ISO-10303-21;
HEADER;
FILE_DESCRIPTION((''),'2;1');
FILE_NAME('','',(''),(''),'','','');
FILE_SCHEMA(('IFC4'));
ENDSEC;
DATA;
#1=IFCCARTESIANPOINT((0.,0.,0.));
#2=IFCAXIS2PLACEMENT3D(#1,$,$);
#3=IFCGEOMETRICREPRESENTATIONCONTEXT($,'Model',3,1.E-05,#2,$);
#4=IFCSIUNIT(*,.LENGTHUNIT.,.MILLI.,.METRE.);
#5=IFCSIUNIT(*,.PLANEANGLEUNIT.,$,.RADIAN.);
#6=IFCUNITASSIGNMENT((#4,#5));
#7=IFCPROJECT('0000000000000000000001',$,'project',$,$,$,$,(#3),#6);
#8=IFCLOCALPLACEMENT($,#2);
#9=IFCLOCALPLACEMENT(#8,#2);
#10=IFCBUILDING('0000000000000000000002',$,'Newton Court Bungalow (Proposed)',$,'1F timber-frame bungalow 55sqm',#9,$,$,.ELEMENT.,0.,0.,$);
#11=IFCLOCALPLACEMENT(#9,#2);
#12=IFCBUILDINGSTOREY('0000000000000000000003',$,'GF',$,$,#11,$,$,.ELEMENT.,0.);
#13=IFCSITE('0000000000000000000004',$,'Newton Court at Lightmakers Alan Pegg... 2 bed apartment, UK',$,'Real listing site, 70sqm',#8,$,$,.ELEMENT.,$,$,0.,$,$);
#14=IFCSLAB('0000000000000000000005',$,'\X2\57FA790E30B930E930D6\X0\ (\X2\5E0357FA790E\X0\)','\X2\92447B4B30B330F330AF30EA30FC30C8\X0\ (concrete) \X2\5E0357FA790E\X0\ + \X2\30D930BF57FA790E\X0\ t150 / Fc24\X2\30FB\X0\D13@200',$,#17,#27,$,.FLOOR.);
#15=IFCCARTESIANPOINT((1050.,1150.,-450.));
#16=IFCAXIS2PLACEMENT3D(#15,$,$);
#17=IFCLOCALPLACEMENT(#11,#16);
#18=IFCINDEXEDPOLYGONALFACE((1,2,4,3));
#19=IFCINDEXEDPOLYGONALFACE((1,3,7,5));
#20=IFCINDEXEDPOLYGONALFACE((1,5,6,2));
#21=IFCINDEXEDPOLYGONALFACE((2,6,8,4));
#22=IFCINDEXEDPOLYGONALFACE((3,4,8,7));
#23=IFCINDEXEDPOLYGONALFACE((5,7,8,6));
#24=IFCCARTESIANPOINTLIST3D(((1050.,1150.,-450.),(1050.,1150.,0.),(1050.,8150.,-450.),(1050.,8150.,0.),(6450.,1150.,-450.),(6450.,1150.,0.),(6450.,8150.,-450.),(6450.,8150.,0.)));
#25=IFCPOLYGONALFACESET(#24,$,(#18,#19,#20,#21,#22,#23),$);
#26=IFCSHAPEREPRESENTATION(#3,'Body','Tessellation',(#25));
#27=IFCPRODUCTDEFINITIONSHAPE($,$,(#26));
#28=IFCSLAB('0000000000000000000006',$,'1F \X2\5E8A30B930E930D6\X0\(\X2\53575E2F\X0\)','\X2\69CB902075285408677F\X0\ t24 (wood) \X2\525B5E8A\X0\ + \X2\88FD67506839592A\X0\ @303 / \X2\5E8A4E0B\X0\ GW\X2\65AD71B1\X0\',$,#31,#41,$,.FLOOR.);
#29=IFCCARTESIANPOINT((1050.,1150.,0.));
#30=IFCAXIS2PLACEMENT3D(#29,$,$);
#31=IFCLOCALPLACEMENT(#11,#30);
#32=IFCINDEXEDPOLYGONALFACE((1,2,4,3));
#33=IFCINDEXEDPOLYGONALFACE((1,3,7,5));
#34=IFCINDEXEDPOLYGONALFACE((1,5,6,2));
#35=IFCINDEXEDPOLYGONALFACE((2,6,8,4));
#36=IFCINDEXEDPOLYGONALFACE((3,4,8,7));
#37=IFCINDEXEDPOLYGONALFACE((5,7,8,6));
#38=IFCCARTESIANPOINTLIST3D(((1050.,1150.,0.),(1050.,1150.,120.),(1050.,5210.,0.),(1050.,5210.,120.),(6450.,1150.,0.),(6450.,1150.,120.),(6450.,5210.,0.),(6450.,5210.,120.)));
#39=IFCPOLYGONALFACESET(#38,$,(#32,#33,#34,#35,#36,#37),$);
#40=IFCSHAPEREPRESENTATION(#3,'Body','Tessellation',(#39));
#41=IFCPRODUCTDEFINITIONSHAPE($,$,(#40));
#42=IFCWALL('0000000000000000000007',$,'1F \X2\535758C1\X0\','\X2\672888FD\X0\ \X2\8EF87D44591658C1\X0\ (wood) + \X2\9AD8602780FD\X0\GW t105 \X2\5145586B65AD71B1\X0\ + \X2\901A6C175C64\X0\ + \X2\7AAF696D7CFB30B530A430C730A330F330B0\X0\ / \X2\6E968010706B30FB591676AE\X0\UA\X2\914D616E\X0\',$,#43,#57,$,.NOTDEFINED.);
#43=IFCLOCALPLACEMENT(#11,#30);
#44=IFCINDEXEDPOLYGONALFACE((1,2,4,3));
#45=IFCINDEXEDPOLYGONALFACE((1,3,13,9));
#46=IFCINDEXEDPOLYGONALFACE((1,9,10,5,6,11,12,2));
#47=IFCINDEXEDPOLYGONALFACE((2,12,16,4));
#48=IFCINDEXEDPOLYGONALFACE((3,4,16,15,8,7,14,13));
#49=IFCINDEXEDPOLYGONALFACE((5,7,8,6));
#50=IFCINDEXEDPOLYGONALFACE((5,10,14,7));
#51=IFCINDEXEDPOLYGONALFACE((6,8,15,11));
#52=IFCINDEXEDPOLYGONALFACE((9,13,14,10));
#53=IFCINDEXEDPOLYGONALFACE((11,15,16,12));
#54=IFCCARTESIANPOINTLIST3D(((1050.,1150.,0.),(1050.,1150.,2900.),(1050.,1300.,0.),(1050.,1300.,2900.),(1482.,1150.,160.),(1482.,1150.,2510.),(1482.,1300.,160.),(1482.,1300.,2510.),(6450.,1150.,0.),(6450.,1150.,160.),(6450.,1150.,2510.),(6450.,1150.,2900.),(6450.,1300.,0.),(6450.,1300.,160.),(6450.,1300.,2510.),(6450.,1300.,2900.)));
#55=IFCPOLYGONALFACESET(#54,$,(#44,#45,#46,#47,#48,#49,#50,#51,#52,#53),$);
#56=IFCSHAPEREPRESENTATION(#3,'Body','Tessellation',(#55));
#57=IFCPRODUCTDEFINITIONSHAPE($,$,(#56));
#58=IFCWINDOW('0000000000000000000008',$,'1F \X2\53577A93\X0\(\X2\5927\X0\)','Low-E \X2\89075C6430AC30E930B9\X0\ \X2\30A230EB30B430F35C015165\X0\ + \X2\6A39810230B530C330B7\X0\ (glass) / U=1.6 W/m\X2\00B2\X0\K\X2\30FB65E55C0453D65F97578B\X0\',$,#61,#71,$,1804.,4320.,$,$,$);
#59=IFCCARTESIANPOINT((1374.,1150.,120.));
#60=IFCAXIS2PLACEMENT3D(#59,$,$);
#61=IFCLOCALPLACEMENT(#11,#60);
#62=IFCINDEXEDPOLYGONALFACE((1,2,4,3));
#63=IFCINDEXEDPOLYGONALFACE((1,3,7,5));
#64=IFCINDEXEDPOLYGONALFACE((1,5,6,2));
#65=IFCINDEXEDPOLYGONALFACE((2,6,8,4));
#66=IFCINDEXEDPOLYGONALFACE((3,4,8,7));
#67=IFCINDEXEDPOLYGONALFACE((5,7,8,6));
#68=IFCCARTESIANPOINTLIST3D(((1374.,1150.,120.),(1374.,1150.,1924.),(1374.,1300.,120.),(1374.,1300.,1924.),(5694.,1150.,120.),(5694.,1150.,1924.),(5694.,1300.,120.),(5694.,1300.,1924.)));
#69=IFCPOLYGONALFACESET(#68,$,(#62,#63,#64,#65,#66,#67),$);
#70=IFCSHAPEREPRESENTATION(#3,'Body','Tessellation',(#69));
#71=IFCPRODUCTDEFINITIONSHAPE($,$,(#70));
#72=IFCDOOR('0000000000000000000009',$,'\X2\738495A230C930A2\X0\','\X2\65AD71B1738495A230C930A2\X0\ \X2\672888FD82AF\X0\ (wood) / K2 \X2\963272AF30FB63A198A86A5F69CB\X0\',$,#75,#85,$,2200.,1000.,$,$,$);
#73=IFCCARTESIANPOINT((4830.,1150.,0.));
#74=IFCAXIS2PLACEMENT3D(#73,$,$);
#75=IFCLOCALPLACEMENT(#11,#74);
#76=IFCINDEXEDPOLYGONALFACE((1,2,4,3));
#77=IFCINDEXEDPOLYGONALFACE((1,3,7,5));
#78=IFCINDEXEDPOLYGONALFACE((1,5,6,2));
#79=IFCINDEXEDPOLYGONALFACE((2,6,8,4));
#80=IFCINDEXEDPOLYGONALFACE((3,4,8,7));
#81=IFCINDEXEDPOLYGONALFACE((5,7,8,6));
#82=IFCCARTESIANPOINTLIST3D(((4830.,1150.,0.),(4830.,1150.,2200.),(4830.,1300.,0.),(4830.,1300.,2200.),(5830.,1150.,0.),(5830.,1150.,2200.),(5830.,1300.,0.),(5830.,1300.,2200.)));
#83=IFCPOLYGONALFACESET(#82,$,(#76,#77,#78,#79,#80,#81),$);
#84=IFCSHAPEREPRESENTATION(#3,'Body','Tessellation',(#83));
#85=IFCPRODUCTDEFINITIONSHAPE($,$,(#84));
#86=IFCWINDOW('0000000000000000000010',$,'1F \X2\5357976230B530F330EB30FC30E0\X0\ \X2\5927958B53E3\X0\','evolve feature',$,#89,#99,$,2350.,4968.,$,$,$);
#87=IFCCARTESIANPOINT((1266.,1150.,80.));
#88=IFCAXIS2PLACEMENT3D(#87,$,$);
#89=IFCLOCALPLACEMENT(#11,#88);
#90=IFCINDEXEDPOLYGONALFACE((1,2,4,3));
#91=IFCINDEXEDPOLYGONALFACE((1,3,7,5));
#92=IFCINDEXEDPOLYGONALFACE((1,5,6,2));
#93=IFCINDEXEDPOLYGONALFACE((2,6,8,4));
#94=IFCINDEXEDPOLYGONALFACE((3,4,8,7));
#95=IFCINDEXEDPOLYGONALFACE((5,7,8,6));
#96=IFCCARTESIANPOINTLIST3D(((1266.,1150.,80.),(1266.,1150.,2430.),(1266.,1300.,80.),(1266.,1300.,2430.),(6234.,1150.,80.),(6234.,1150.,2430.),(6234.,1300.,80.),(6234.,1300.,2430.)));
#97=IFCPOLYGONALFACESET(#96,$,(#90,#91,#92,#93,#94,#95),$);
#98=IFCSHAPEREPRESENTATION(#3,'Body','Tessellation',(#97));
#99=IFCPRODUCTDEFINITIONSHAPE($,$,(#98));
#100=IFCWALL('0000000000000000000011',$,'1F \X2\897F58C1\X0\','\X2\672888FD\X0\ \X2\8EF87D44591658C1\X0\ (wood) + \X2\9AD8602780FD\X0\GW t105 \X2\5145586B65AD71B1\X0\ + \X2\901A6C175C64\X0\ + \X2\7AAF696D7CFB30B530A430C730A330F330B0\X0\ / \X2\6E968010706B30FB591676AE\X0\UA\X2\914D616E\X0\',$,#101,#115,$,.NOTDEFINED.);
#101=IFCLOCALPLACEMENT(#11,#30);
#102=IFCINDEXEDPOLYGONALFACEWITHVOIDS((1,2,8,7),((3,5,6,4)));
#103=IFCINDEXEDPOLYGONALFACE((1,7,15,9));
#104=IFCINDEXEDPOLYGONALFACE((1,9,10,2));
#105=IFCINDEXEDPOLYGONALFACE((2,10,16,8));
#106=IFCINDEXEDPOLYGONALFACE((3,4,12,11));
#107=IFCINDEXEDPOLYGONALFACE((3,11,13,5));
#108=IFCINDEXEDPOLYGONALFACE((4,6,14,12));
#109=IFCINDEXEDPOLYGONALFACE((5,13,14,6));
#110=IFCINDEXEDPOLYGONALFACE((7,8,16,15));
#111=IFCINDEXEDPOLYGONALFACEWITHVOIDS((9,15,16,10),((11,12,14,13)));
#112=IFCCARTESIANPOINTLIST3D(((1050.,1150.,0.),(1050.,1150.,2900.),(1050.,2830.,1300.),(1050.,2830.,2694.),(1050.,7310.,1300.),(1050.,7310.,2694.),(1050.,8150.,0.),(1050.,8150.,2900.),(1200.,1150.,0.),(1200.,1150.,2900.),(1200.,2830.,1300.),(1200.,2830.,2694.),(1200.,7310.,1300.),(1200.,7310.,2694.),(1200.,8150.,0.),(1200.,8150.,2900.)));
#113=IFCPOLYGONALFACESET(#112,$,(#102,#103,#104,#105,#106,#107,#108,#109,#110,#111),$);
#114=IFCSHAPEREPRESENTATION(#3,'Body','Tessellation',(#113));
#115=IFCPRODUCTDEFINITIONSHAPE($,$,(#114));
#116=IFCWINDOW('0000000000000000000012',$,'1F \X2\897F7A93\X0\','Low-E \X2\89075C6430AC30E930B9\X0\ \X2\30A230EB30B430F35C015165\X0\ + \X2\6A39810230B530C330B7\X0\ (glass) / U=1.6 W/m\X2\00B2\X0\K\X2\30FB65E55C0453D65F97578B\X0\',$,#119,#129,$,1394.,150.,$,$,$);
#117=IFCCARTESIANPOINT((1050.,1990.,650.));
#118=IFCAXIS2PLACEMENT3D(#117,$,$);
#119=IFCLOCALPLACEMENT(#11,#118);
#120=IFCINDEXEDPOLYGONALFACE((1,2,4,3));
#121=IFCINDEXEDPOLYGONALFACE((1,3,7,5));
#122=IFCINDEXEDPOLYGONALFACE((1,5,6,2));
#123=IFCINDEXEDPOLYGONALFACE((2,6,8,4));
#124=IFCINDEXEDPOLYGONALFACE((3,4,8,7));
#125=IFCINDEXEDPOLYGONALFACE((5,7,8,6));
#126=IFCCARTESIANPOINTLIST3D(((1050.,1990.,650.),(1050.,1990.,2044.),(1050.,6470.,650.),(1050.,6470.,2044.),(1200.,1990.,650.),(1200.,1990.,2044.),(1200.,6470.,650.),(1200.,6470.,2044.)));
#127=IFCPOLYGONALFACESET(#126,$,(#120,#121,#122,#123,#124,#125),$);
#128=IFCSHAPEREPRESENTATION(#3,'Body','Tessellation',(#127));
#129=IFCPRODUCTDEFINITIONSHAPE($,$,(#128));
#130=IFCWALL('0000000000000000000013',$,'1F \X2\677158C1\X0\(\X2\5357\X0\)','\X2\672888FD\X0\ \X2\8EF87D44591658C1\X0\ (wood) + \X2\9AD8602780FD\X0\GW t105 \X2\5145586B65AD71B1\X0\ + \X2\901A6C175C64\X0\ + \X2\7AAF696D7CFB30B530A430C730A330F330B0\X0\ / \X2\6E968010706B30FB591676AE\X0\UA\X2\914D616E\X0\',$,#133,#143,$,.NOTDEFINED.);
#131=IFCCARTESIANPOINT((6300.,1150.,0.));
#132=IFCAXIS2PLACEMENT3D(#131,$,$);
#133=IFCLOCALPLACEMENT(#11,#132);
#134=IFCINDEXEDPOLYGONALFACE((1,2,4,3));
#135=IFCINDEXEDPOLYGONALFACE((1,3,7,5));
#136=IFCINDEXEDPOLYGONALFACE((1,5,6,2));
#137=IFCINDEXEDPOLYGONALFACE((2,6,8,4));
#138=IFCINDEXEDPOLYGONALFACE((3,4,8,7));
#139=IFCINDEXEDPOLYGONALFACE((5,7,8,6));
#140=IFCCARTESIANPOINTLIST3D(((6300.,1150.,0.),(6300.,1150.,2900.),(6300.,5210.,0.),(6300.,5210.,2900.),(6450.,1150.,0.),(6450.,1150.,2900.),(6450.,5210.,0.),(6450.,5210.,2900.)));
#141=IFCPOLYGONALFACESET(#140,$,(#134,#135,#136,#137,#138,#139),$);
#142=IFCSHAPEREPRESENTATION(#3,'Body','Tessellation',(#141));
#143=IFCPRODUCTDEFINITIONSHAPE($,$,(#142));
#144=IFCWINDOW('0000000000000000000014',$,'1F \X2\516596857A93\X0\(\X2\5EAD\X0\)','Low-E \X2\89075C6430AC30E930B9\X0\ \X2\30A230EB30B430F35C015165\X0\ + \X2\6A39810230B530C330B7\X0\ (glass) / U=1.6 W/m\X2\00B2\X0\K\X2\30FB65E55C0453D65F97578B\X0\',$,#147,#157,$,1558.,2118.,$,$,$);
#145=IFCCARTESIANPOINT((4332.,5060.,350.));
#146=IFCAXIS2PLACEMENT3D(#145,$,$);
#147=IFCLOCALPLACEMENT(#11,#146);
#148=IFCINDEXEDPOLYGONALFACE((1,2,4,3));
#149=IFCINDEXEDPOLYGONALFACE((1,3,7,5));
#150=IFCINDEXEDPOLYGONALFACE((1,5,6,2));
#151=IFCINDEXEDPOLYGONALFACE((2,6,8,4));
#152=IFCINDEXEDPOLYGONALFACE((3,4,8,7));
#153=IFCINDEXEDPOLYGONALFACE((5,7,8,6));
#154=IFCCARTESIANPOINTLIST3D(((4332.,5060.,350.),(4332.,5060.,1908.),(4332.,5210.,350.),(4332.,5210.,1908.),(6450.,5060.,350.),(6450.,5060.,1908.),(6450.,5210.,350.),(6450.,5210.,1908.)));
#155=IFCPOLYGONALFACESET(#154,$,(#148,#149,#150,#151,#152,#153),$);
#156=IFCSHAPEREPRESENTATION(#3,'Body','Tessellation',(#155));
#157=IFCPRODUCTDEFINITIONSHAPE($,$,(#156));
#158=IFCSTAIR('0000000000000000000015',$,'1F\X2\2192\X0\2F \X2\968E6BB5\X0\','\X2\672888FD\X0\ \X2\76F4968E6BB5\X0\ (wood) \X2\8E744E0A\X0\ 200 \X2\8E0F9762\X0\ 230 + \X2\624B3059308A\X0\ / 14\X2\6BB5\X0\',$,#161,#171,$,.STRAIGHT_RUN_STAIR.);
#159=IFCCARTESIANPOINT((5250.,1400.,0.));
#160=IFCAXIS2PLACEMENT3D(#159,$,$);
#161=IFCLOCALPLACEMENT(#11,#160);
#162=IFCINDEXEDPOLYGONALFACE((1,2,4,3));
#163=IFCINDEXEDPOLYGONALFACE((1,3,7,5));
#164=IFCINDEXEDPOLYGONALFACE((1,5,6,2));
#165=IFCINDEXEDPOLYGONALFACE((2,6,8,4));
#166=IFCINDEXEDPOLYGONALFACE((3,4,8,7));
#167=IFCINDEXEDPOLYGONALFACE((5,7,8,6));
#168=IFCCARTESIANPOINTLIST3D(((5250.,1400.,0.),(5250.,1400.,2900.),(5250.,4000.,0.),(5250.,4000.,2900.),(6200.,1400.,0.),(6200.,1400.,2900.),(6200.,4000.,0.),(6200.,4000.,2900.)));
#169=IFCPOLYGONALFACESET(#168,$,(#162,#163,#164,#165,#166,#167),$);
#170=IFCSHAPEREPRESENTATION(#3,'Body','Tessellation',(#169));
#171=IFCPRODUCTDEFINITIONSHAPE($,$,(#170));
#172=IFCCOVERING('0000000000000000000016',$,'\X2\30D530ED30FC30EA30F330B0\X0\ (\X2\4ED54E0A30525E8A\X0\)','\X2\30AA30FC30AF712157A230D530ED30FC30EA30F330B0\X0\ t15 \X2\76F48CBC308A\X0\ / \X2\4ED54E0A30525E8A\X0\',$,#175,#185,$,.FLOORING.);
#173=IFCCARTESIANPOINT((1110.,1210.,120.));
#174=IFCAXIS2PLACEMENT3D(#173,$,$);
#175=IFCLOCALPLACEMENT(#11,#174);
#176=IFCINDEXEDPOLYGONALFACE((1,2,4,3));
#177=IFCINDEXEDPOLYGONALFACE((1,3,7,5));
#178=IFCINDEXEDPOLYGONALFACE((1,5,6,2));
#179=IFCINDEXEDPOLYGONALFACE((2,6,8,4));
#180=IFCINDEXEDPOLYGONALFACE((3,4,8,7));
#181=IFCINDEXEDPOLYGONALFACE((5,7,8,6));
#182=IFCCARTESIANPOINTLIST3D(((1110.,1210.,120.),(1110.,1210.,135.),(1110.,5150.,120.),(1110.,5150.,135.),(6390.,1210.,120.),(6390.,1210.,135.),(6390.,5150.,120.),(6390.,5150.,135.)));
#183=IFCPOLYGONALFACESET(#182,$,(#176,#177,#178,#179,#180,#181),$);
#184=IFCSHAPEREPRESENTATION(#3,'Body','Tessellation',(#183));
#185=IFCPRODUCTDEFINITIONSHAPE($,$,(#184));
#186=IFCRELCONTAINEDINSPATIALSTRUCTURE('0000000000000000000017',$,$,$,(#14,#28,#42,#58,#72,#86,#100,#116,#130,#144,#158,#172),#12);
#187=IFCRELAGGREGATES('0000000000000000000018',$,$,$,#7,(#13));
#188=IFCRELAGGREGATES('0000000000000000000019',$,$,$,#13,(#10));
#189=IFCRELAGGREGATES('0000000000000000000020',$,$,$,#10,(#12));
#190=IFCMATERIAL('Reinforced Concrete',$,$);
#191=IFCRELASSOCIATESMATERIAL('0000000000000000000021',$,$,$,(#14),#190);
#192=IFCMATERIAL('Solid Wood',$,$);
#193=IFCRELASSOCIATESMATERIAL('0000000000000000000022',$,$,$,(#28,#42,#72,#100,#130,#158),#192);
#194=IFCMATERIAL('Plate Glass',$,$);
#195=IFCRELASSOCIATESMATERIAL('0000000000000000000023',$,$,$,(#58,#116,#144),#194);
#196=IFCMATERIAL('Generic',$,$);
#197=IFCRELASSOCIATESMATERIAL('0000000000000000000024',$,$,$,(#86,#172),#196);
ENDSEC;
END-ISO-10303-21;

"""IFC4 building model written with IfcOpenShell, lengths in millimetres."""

from ifc_helpers import new_model, si_unit, frame, frame_2d, origin, place, context, project, spatial, rectangle, extrude, material, element, fill, save


model = new_model("IFC4")

# Units and contexts
model_context = context("Model", 3, precision=1e-05, world=origin())
ifc_project = project(units=[si_unit("LENGTHUNIT", "METRE", prefix="MILLI"), si_unit("PLANEANGLEUNIT", "RADIAN")], contexts=[model_context])

# Site, building, storey
site_placement = place(None, origin())
site = spatial("IfcSite", under=ifc_project, at=site_placement, Name="Newton Court at Lightmakers Alan Pegg... 2 bed apartment, UK", ObjectType="Real listing site, 70sqm", CompositionType="ELEMENT", RefElevation=0.0)
building_placement = place(site_placement, origin())
building = spatial("IfcBuilding", under=site, at=building_placement, Name="Newton Court Bungalow (Proposed)", ObjectType="1F timber-frame bungalow 55sqm", CompositionType="ELEMENT", ElevationOfRefHeight=0.0, ElevationOfTerrain=0.0)
storey_placement = place(building_placement, origin())
storey = spatial("IfcBuildingStorey", under=building, at=storey_placement, Name="GF", CompositionType="ELEMENT", Elevation=0.0)

# Slabs
ifc_material_1 = material(Name="Reinforced Concrete")
slab_1_placement = place(storey_placement, frame((1050.0, 1150.0, -450.0)))
element("IfcSlab", 1, at=slab_1_placement, inside=storey, material=ifc_material_1, Name="基礎スラブ (布基礎)", Description="鉄筋コンクリート (concrete) 布基礎 + ベタ基礎 t150 / Fc24・D13@200", PredefinedType="FLOOR", context=model_context, shape_type="SweptSolid", body=[
    extrude(rectangle(XDim=5400.0, YDim=7000.0, at=frame_2d((2700.0, 3500.0))), frame((1050.0, 1150.0, -450.0)), (0.0, 0.0, 1.0), 450.0),
])
ifc_material_2 = material(Name="Solid Wood")
slab_2_placement = place(storey_placement, frame((1050.0, 1150.0, 0.0)))
element("IfcSlab", 2, at=slab_2_placement, inside=storey, material=ifc_material_2, Name="1F 床スラブ(南帯)", Description="構造用合板 t24 (wood) 剛床 + 製材根太 @303 / 床下 GW断熱", PredefinedType="FLOOR", context=model_context, shape_type="SweptSolid", body=[
    extrude(rectangle(XDim=5400.0, YDim=4060.0, at=frame_2d((2700.0, 2030.0))), frame((1050.0, 1150.0, 0.0)), (0.0, 0.0, 1.0), 120.0),
])

# Wall, openings, windows, door
wall_1_placement = place(storey_placement, frame((1050.0, 1150.0, 0.0)))
wall_1 = element("IfcWall", 3, at=wall_1_placement, inside=storey, material=ifc_material_2, Name="1F 南壁", Description="木製 軸組外壁 (wood) + 高性能GW t105 充填断熱 + 通気層 + 窯業系サイディング / 準耐火・外皮UA配慮", PredefinedType="NOTDEFINED", context=model_context, shape_type="SweptSolid", body=[
    extrude(rectangle(XDim=5400.0, YDim=150.0, at=frame_2d((2700.0, 75.0))), frame((1050.0, 1150.0, 0.0)), (0.0, 0.0, 1.0), 2900.0),
])
opening_1_placement = place(storey_placement, frame((1374.0, 1150.0, 120.0)))
opening_1 = element("IfcOpeningElement", 4, at=opening_1_placement, cuts=wall_1, PredefinedType="NOTDEFINED", context=model_context, shape_type="SweptSolid", body=[
    extrude(rectangle(XDim=4320.0, YDim=150.0, at=frame_2d((2160.0, 75.0))), frame((1374.0, 1150.0, 120.0)), (0.0, 0.0, 1.0), 1804.0),
])
opening_2_placement = place(storey_placement, frame((4830.0, 1150.0, 0.0)))
opening_2 = element("IfcOpeningElement", 5, at=opening_2_placement, cuts=wall_1, PredefinedType="NOTDEFINED", context=model_context, shape_type="SweptSolid", body=[
    extrude(rectangle(XDim=1000.0, YDim=150.0, at=frame_2d((500.0, 75.0))), frame((4830.0, 1150.0, 0.0)), (0.0, 0.0, 1.0), 2200.0),
])
opening_3_placement = place(storey_placement, frame((1266.0, 1150.0, 80.0)))
opening_3 = element("IfcOpeningElement", 6, at=opening_3_placement, cuts=wall_1, PredefinedType="NOTDEFINED", context=model_context, shape_type="SweptSolid", body=[
    extrude(rectangle(XDim=4968.0, YDim=150.0, at=frame_2d((2484.0, 75.0))), frame((1266.0, 1150.0, 80.0)), (0.0, 0.0, 1.0), 2350.0),
])
ifc_material_3 = material(Name="Plate Glass")
window_1_placement = place(storey_placement, frame((1374.0, 1150.0, 120.0)))
window_1 = element("IfcWindow", 7, at=window_1_placement, inside=storey, material=ifc_material_3, Name="1F 南窓(大)", Description="Low-E 複層ガラス アルゴン封入 + 樹脂サッシ (glass) / U=1.6 W/m²K・日射取得型", OverallHeight=1804.0, OverallWidth=4320.0, context=model_context, shape_type="SweptSolid", body=[
    extrude(rectangle(XDim=4320.0, YDim=150.0, at=frame_2d((2160.0, 75.0))), frame((1374.0, 1150.0, 120.0)), (0.0, 0.0, 1.0), 1804.0),
])
fill(opening_1, window_1)
door_1_placement = place(storey_placement, frame((4830.0, 1150.0, 0.0)))
door_1 = element("IfcDoor", 8, at=door_1_placement, inside=storey, material=ifc_material_2, Name="玄関ドア", Description="断熱玄関ドア 木製芯 (wood) / K2 防犯・採風機構", OverallHeight=2200.0, OverallWidth=1000.0, context=model_context, shape_type="SweptSolid", body=[
    extrude(rectangle(XDim=1000.0, YDim=150.0, at=frame_2d((500.0, 75.0))), frame((4830.0, 1150.0, 0.0)), (0.0, 0.0, 1.0), 2200.0),
])
fill(opening_2, door_1)
ifc_material_4 = material(Name="Generic")
window_2_placement = place(storey_placement, frame((1266.0, 1150.0, 80.0)))
window_2 = element("IfcWindow", 9, at=window_2_placement, inside=storey, material=ifc_material_4, Name="1F 南面サンルーム 大開口", Description="evolve feature", OverallHeight=2350.0, OverallWidth=4968.0, context=model_context, shape_type="SweptSolid", body=[
    extrude(rectangle(XDim=4968.0, YDim=150.0, at=frame_2d((2484.0, 75.0))), frame((1266.0, 1150.0, 80.0)), (0.0, 0.0, 1.0), 2350.0),
])
fill(opening_3, window_2)

# Walls, openings, windows
wall_2_placement = place(storey_placement, frame((1050.0, 1150.0, 0.0)))
wall_2 = element("IfcWall", 10, at=wall_2_placement, inside=storey, material=ifc_material_2, Name="1F 西壁", Description="木製 軸組外壁 (wood) + 高性能GW t105 充填断熱 + 通気層 + 窯業系サイディング / 準耐火・外皮UA配慮", PredefinedType="NOTDEFINED", context=model_context, shape_type="SweptSolid", body=[
    extrude(rectangle(XDim=150.0, YDim=7000.0, at=frame_2d((75.0, 3500.0))), frame((1050.0, 1150.0, 0.0)), (0.0, 0.0, 1.0), 2900.0),
])
opening_4_placement = place(storey_placement, frame((1050.0, 1990.0, 650.0)))
opening_4 = element("IfcOpeningElement", 11, at=opening_4_placement, cuts=wall_2, PredefinedType="NOTDEFINED", context=model_context, shape_type="SweptSolid", body=[
    extrude(rectangle(XDim=150.0, YDim=4480.0, at=frame_2d((75.0, 2240.0))), frame((1050.0, 1990.0, 650.0)), (0.0, 0.0, 1.0), 1394.0),
])
window_3_placement = place(storey_placement, frame((1050.0, 1990.0, 650.0)))
window_3 = element("IfcWindow", 12, at=window_3_placement, inside=storey, material=ifc_material_3, Name="1F 西窓", Description="Low-E 複層ガラス アルゴン封入 + 樹脂サッシ (glass) / U=1.6 W/m²K・日射取得型", OverallHeight=1394.0, OverallWidth=150.0, context=model_context, shape_type="SweptSolid", body=[
    extrude(rectangle(XDim=150.0, YDim=4480.0, at=frame_2d((75.0, 2240.0))), frame((1050.0, 1990.0, 650.0)), (0.0, 0.0, 1.0), 1394.0),
])
fill(opening_4, window_3)
wall_3_placement = place(storey_placement, frame((6300.0, 1150.0, 0.0)))
wall_3 = element("IfcWall", 13, at=wall_3_placement, inside=storey, material=ifc_material_2, Name="1F 東壁(南)", Description="木製 軸組外壁 (wood) + 高性能GW t105 充填断熱 + 通気層 + 窯業系サイディング / 準耐火・外皮UA配慮", PredefinedType="NOTDEFINED", context=model_context, shape_type="SweptSolid", body=[
    extrude(rectangle(XDim=150.0, YDim=4060.0, at=frame_2d((75.0, 2030.0))), frame((6300.0, 1150.0, 0.0)), (0.0, 0.0, 1.0), 2900.0),
])
opening_5_placement = place(storey_placement, frame((4332.0, 5060.0, 350.0)))
opening_5 = element("IfcOpeningElement", 14, at=opening_5_placement, cuts=wall_3, PredefinedType="NOTDEFINED", context=model_context, shape_type="SweptSolid", body=[
    extrude(rectangle(XDim=2118.0, YDim=150.0, at=frame_2d((1059.0, 75.0))), frame((4332.0, 5060.0, 350.0)), (0.0, 0.0, 1.0), 1558.0),
])
window_4_placement = place(storey_placement, frame((4332.0, 5060.0, 350.0)))
window_4 = element("IfcWindow", 15, at=window_4_placement, inside=storey, material=ifc_material_3, Name="1F 入隅窓(庭)", Description="Low-E 複層ガラス アルゴン封入 + 樹脂サッシ (glass) / U=1.6 W/m²K・日射取得型", OverallHeight=1558.0, OverallWidth=2118.0, context=model_context, shape_type="SweptSolid", body=[
    extrude(rectangle(XDim=2118.0, YDim=150.0, at=frame_2d((1059.0, 75.0))), frame((4332.0, 5060.0, 350.0)), (0.0, 0.0, 1.0), 1558.0),
])
fill(opening_5, window_4)

# Stair
stair_placement = place(storey_placement, frame((5250.0, 1400.0, 0.0)))
element("IfcStair", 16, at=stair_placement, inside=storey, material=ifc_material_2, Name="1F→2F 階段", Description="木製 直階段 (wood) 蹴上 200 踏面 230 + 手すり / 14段", PredefinedType="STRAIGHT_RUN_STAIR", context=model_context, shape_type="SweptSolid", body=[
    extrude(rectangle(XDim=950.0, YDim=2600.0, at=frame_2d((475.0, 1300.0))), frame((5250.0, 1400.0, 0.0)), (0.0, 0.0, 1.0), 2900.0),
])

# Covering
covering_placement = place(storey_placement, frame((1110.0, 1210.0, 120.0)))
element("IfcCovering", 17, at=covering_placement, inside=storey, material=ifc_material_4, Name="フローリング (仕上げ床)", Description="オーク無垢フローリング t15 直貼り / 仕上げ床", PredefinedType="FLOORING", context=model_context, shape_type="SweptSolid", body=[
    extrude(rectangle(XDim=5280.0, YDim=3940.0, at=frame_2d((2640.0, 1970.0))), frame((1110.0, 1210.0, 120.0)), (0.0, 0.0, 1.0), 15.0),
])

save(model, "model.ifc")
